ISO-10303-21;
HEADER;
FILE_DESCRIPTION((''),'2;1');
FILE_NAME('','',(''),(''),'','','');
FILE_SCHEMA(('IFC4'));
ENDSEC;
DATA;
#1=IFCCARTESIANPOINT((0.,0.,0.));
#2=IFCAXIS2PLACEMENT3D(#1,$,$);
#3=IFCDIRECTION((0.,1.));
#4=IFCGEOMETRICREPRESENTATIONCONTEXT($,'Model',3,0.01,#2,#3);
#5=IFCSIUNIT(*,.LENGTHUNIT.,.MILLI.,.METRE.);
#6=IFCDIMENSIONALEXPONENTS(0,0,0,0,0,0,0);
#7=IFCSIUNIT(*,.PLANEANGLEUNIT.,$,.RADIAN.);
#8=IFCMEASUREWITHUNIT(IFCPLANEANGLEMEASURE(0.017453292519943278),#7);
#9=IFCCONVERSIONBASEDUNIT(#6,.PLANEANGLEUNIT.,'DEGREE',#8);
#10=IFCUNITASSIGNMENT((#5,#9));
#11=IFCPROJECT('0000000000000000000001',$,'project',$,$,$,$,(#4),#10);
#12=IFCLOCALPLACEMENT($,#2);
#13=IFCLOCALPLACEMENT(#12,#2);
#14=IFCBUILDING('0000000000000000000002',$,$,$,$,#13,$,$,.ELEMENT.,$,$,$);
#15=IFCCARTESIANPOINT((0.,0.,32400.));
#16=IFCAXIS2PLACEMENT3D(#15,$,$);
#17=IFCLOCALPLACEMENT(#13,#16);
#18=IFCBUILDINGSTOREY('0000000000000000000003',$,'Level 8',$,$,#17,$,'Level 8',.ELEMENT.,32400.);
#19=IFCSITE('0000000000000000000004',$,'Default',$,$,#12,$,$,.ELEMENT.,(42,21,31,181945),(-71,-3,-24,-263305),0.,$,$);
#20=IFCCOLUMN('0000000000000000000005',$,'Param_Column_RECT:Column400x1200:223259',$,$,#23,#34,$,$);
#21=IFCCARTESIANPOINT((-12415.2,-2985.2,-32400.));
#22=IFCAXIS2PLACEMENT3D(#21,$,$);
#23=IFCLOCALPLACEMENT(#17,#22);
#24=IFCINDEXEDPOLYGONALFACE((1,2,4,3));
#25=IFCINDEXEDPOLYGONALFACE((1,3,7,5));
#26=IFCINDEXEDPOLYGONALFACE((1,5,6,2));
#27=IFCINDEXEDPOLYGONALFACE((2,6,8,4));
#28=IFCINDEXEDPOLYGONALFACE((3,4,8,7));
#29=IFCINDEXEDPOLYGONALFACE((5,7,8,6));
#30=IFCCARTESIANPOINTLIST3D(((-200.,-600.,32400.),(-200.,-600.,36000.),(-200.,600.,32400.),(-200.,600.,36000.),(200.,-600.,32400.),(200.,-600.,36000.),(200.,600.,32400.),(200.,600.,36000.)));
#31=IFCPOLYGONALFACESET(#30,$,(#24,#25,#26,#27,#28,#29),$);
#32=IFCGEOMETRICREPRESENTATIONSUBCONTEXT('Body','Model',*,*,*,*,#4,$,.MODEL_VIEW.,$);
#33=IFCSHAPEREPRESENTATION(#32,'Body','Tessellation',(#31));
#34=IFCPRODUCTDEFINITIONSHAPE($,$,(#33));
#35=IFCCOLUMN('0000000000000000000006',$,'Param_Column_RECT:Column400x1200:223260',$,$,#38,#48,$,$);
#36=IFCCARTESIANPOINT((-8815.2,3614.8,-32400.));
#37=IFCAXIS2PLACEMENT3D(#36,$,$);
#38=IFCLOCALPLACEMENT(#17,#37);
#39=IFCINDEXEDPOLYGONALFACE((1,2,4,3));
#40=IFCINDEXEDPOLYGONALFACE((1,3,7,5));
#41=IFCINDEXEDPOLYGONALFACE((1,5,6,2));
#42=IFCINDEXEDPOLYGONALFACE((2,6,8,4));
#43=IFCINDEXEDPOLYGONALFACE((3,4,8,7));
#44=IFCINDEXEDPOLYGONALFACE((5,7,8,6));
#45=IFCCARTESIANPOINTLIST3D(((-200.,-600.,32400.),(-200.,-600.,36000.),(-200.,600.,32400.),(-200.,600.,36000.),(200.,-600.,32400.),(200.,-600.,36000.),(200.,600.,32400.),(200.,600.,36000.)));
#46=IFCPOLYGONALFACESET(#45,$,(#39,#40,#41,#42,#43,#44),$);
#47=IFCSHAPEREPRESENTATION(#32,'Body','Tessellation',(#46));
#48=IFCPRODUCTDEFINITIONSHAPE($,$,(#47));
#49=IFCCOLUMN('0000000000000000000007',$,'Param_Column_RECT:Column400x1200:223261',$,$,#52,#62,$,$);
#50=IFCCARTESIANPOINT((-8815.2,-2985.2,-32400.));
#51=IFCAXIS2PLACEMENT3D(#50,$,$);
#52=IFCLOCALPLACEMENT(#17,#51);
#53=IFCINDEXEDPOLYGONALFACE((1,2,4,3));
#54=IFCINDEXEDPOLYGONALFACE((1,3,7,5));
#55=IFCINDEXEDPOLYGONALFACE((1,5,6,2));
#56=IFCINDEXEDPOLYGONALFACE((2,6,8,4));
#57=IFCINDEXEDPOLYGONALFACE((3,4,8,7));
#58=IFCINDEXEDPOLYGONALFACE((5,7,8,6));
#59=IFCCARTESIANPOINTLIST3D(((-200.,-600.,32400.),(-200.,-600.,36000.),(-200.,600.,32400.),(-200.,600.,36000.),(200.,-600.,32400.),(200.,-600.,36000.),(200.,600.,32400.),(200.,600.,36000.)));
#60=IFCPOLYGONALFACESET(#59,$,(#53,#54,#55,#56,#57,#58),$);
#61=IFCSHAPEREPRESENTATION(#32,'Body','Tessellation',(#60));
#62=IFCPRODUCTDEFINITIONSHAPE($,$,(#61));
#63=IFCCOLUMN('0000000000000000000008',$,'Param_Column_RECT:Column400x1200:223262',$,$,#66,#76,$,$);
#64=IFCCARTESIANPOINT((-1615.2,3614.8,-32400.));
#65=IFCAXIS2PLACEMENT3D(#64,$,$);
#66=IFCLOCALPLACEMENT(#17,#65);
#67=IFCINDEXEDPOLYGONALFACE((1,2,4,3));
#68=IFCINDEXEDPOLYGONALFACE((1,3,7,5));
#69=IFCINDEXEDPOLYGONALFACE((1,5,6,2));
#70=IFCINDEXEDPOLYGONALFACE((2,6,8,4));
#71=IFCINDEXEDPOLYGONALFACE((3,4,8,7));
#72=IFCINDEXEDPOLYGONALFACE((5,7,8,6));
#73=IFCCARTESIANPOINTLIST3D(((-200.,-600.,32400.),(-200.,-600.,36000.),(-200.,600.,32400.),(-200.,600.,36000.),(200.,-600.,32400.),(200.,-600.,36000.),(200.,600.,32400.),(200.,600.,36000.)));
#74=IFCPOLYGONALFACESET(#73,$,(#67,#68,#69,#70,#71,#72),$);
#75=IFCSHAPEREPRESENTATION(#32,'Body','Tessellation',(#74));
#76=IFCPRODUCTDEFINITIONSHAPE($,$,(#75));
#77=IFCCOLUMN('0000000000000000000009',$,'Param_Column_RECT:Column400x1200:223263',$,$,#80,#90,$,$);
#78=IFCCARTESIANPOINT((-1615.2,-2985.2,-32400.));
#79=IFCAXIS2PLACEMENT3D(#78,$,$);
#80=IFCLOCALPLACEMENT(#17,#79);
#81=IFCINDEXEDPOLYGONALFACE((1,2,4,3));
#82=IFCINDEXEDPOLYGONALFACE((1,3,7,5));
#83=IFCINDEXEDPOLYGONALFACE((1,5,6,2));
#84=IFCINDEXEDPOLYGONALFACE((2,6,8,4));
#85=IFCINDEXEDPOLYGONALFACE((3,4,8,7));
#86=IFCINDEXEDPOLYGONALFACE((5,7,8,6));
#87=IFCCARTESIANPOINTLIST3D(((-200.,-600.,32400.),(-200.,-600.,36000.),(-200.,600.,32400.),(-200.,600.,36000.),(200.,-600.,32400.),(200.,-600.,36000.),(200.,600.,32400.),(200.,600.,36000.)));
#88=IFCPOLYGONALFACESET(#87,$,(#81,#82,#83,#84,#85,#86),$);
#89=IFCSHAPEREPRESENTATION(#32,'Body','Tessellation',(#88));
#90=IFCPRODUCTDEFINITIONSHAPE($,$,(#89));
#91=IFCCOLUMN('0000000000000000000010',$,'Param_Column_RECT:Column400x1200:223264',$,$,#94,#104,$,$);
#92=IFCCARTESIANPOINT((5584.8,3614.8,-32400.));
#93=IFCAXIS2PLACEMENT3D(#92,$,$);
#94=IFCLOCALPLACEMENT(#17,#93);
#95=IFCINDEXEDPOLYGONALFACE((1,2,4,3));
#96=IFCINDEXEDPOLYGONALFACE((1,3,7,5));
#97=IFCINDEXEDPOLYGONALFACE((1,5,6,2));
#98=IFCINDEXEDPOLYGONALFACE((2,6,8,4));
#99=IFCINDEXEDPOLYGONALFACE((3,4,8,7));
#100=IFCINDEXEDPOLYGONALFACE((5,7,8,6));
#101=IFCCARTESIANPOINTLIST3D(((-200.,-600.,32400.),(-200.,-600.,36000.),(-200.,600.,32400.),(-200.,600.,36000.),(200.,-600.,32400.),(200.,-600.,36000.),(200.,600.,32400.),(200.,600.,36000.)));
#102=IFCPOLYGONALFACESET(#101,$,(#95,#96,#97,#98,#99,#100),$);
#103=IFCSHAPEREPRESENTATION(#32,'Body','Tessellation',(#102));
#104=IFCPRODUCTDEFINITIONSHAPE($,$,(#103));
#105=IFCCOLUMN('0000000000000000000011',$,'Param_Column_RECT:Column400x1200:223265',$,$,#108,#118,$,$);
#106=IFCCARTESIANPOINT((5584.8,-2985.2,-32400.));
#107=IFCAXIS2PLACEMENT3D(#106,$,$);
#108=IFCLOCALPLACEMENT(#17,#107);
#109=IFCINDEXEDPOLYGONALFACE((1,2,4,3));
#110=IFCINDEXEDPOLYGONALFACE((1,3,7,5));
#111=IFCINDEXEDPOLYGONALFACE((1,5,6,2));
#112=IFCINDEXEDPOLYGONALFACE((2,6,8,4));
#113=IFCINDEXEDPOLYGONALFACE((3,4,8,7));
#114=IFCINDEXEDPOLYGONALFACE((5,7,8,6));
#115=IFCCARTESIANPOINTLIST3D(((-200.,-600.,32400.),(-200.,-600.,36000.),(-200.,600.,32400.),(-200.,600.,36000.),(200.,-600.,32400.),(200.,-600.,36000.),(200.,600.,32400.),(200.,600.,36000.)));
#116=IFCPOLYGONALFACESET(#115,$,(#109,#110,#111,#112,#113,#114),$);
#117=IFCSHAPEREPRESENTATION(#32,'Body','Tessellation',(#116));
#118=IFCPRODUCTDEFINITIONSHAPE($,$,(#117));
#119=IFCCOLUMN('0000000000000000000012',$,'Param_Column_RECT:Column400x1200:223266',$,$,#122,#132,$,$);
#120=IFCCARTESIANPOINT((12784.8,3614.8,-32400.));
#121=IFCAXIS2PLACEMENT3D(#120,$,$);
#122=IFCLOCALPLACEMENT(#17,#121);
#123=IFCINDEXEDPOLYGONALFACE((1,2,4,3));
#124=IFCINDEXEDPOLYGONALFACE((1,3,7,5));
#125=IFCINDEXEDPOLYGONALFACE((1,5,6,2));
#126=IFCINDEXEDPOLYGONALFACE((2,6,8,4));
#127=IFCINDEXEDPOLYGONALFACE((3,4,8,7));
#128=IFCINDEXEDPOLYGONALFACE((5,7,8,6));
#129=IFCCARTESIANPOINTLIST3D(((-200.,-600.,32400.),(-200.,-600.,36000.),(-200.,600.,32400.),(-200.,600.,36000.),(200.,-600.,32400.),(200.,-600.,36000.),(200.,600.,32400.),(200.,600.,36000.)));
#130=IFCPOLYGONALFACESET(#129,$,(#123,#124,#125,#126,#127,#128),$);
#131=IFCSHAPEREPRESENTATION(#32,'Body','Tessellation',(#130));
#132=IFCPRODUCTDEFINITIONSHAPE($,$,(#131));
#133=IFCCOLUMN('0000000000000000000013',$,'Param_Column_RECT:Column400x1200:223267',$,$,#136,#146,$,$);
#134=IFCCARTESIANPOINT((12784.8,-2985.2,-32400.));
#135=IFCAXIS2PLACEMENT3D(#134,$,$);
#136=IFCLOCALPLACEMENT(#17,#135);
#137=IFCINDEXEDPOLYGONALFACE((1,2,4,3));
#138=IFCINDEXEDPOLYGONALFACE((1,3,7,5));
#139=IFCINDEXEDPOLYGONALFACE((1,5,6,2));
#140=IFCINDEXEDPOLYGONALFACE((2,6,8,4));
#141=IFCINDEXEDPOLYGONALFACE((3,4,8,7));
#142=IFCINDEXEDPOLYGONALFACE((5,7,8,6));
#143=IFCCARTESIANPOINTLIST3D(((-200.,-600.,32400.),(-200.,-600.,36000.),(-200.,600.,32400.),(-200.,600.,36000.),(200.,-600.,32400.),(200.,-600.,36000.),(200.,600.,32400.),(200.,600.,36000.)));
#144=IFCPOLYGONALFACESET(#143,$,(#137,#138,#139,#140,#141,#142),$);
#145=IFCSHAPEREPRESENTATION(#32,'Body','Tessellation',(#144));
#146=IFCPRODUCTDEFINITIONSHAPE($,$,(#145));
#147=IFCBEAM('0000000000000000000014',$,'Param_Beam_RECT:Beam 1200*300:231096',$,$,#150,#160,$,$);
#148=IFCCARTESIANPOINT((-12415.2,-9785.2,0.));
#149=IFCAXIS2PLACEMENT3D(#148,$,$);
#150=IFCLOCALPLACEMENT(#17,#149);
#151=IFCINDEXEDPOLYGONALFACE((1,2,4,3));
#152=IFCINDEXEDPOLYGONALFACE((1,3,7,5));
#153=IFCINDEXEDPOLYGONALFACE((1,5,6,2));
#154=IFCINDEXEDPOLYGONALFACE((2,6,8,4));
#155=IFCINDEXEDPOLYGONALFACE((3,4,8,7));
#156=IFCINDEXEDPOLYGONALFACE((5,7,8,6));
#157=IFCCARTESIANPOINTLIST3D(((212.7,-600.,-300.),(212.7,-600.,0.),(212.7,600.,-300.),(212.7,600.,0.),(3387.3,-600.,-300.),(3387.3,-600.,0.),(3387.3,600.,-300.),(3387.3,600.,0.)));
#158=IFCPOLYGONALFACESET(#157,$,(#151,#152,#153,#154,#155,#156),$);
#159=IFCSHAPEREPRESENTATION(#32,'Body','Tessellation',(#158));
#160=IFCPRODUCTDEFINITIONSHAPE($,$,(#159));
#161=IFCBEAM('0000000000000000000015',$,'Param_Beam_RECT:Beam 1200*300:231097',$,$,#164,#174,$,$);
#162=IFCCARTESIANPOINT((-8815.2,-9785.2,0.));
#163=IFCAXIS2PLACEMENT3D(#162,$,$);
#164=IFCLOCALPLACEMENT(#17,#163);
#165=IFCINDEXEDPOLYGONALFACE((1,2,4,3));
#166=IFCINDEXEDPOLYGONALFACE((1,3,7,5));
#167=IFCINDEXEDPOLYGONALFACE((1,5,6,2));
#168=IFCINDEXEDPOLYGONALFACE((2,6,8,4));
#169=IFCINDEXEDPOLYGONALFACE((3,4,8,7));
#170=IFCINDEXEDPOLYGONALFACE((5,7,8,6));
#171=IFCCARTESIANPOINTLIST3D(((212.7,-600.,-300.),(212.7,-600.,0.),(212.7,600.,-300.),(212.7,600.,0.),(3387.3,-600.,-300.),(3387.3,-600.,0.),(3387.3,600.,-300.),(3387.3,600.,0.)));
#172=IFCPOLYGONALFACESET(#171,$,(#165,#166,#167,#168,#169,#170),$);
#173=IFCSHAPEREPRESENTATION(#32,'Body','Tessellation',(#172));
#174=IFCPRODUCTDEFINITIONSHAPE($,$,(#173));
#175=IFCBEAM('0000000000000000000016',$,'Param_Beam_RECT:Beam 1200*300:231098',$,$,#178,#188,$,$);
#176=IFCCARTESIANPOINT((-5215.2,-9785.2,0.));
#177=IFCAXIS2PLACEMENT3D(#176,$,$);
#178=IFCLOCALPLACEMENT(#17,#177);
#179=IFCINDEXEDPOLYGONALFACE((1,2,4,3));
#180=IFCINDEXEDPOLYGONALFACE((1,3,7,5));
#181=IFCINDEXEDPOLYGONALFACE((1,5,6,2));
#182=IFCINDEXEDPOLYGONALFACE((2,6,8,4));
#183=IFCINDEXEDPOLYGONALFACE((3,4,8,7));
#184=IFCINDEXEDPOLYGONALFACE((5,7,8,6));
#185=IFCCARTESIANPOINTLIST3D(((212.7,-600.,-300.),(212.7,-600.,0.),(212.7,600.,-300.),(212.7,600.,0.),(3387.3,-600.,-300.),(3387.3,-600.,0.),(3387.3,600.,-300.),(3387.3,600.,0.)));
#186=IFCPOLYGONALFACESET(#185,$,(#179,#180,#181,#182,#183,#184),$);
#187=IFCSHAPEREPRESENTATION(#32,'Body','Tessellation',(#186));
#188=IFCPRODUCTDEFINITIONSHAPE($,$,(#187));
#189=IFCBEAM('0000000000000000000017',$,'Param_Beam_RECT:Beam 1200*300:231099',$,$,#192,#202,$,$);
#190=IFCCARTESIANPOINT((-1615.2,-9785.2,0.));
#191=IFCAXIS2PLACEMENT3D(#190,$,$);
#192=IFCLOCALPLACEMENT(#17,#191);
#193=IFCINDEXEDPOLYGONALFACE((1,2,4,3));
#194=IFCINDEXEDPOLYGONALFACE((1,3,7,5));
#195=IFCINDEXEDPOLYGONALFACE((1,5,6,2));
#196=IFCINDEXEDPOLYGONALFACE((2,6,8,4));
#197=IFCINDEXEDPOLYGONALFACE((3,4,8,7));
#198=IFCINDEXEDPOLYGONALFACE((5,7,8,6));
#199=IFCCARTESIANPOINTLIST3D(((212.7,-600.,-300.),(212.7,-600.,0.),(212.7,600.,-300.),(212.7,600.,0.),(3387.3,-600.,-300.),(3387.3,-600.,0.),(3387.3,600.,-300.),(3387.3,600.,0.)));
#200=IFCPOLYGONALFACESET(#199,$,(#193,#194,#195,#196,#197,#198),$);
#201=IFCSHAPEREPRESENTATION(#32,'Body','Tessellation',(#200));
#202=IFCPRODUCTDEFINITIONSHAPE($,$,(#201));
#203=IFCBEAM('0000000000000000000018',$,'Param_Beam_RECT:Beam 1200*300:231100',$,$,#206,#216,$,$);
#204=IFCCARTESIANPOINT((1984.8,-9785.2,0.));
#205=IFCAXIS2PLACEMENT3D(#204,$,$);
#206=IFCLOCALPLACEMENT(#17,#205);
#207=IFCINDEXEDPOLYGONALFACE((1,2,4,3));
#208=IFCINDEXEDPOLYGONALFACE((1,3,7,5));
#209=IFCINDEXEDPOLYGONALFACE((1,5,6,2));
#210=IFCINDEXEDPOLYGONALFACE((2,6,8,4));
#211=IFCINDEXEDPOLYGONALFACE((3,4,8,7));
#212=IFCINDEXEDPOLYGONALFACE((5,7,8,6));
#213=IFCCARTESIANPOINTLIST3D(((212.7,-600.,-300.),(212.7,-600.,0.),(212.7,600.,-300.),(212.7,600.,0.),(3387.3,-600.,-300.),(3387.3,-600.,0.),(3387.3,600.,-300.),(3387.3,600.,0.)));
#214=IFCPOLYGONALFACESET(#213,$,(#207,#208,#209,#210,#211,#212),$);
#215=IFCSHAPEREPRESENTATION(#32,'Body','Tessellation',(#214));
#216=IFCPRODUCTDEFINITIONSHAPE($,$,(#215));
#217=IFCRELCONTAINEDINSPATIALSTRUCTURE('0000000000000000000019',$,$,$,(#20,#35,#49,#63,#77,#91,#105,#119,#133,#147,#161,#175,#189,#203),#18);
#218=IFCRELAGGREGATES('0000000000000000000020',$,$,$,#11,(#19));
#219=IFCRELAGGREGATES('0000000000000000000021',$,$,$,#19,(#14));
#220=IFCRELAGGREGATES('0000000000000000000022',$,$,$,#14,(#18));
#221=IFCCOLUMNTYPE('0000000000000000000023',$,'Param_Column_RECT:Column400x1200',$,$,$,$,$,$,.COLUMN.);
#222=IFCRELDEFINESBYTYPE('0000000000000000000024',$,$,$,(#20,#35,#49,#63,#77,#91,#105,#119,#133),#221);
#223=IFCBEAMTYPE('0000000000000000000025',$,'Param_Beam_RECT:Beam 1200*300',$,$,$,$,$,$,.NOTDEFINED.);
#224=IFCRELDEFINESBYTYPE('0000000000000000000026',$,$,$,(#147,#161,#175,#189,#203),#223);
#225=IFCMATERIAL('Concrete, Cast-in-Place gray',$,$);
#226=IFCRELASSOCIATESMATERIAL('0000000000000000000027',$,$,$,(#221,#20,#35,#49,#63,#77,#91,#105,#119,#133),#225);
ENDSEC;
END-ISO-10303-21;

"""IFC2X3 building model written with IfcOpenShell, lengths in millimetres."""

from ifc_helpers import new_model, entity, si_unit, converted_unit, direction, frame, frame_2d, origin, origin_2d_with_axis, place, context, subcontext, project, spatial, rectangle, extrude, source, transform, mapped, material, type_object, type_shapes, element, save


model = new_model("IFC2X3")

# Units and contexts
model_context = context("Model", 3, precision=0.01, world=origin(), true_north=direction((0.0, 1.0)))
body_context = subcontext(model_context, "Body", "Model", "MODEL_VIEW")
ifc_project = project(units=[si_unit("LENGTHUNIT", "METRE", prefix="MILLI"), converted_unit("PLANEANGLEUNIT", "DEGREE", entity("IfcPlaneAngleMeasure", 0.017453292519943278), si_unit("PLANEANGLEUNIT", "RADIAN"), dimensions=[0, 0, 0, 0, 0, 0, 0])], contexts=[model_context])

# Site, building, storey
site_placement = place(None, origin())
site = spatial("IfcSite", under=ifc_project, at=site_placement, Name="Default", CompositionType="ELEMENT", RefLatitude=(42, 21, 31, 181945), RefLongitude=(-71, -3, -24, -263305), RefElevation=0.0)
building_placement = place(site_placement, origin())
building = spatial("IfcBuilding", under=site, at=building_placement, CompositionType="ELEMENT")
storey_placement = place(building_placement, frame((0.0, 0.0, 32400.0)))
storey = spatial("IfcBuildingStorey", under=building, at=storey_placement, Name="Level 8", LongName="Level 8", CompositionType="ELEMENT", Elevation=32400.0)

# Columns
ifc_material_1 = material(Name="Concrete, Cast-in-Place gray")
column_type_1 = type_object("IfcColumnType", Name="Param_Column_RECT:Column400x1200", PredefinedType="COLUMN", material=ifc_material_1)
shared_shape_1 = source(origin(), body_context, "Body", "SweptSolid", [
    extrude(rectangle(XDim=400.0, YDim=1200.0, at=origin_2d_with_axis()), frame((0.0, 0.0, 32400.0), z_axis=(0.0, 0.0, 1.0), x_axis=(-1.0, 0.0, 0.0)), (0.0, 0.0, 1.0), 3600.0),
])
type_shapes(column_type_1, [shared_shape_1])
for number, where, name in (
    (1, (-12415.2, -2985.2, -32400.0), "Param_Column_RECT:Column400x1200:223259"),
    (2, (-8815.2, 3614.8, -32400.0), "Param_Column_RECT:Column400x1200:223260"),
    (3, (-8815.2, -2985.2, -32400.0), "Param_Column_RECT:Column400x1200:223261"),
    (4, (-1615.2, 3614.8, -32400.0), "Param_Column_RECT:Column400x1200:223262"),
    (5, (-1615.2, -2985.2, -32400.0), "Param_Column_RECT:Column400x1200:223263"),
    (6, (5584.8, 3614.8, -32400.0), "Param_Column_RECT:Column400x1200:223264"),
    (7, (5584.8, -2985.2, -32400.0), "Param_Column_RECT:Column400x1200:223265"),
    (8, (12784.8, 3614.8, -32400.0), "Param_Column_RECT:Column400x1200:223266"),
    (9, (12784.8, -2985.2, -32400.0), "Param_Column_RECT:Column400x1200:223267"),
):
    element("IfcColumn", number, at=place(storey_placement, frame(where)), inside=storey, type_object=column_type_1, material=ifc_material_1, Name=name, context=body_context, shape_type="MappedRepresentation", body=[
        mapped(shared_shape_1, transform((0.0, 0.0, 0.0), scale=1.0)),
    ])

# Beams
beam_type = type_object("IfcBeamType", Name="Param_Beam_RECT:Beam 1200*300", PredefinedType="NOTDEFINED")
beam_1_placement = place(storey_placement, frame((-12415.2, -9785.2, 0.0)))
element("IfcBeam", 10, at=beam_1_placement, inside=storey, type_object=beam_type, Name="Param_Beam_RECT:Beam 1200*300:231096", context=body_context, shape_type="SweptSolid", body=[
    extrude(rectangle(XDim=300.0, YDim=1200.0, at=frame_2d((0.0, 0.0), x_axis=(1.0, 0.0))), frame((212.7, 0.0, -150.0), z_axis=(1.0, 0.0, 0.0), x_axis=(0.0, 0.0, -1.0)), (0.0, 0.0, 1.0), 3174.6),
])
beam_2_placement = place(storey_placement, frame((-8815.2, -9785.2, 0.0)))
element("IfcBeam", 11, at=beam_2_placement, inside=storey, type_object=beam_type, Name="Param_Beam_RECT:Beam 1200*300:231097", context=body_context, shape_type="SweptSolid", body=[
    extrude(rectangle(XDim=300.0, YDim=1200.0, at=frame_2d((0.0, 0.0), x_axis=(1.0, 0.0))), frame((212.7, 0.0, -150.0), z_axis=(1.0, 0.0, 0.0), x_axis=(0.0, 0.0, -1.0)), (0.0, 0.0, 1.0), 3174.6),
])
beam_3_placement = place(storey_placement, frame((-5215.2, -9785.2, 0.0)))
element("IfcBeam", 12, at=beam_3_placement, inside=storey, type_object=beam_type, Name="Param_Beam_RECT:Beam 1200*300:231098", context=body_context, shape_type="SweptSolid", body=[
    extrude(rectangle(XDim=300.0, YDim=1200.0, at=frame_2d((0.0, 0.0), x_axis=(1.0, 0.0))), frame((212.7, 0.0, -150.0), z_axis=(1.0, 0.0, 0.0), x_axis=(0.0, 0.0, -1.0)), (0.0, 0.0, 1.0), 3174.6),
])
beam_4_placement = place(storey_placement, frame((-1615.2, -9785.2, 0.0)))
element("IfcBeam", 13, at=beam_4_placement, inside=storey, type_object=beam_type, Name="Param_Beam_RECT:Beam 1200*300:231099", context=body_context, shape_type="SweptSolid", body=[
    extrude(rectangle(XDim=300.0, YDim=1200.0, at=origin_2d_with_axis()), frame((212.7, 0.0, -150.0), z_axis=(1.0, 0.0, 0.0), x_axis=(0.0, 0.0, -1.0)), (0.0, 0.0, 1.0), 3174.6),
])
beam_5_placement = place(storey_placement, frame((1984.8, -9785.2, 0.0)))
element("IfcBeam", 14, at=beam_5_placement, inside=storey, type_object=beam_type, Name="Param_Beam_RECT:Beam 1200*300:231100", context=body_context, shape_type="SweptSolid", body=[
    extrude(rectangle(XDim=300.0, YDim=1200.0, at=origin_2d_with_axis()), frame((212.7, 0.0, -150.0), z_axis=(1.0, 0.0, 0.0), x_axis=(0.0, 0.0, -1.0)), (0.0, 0.0, 1.0), 3174.6),
])

save(model, "model.ifc")
